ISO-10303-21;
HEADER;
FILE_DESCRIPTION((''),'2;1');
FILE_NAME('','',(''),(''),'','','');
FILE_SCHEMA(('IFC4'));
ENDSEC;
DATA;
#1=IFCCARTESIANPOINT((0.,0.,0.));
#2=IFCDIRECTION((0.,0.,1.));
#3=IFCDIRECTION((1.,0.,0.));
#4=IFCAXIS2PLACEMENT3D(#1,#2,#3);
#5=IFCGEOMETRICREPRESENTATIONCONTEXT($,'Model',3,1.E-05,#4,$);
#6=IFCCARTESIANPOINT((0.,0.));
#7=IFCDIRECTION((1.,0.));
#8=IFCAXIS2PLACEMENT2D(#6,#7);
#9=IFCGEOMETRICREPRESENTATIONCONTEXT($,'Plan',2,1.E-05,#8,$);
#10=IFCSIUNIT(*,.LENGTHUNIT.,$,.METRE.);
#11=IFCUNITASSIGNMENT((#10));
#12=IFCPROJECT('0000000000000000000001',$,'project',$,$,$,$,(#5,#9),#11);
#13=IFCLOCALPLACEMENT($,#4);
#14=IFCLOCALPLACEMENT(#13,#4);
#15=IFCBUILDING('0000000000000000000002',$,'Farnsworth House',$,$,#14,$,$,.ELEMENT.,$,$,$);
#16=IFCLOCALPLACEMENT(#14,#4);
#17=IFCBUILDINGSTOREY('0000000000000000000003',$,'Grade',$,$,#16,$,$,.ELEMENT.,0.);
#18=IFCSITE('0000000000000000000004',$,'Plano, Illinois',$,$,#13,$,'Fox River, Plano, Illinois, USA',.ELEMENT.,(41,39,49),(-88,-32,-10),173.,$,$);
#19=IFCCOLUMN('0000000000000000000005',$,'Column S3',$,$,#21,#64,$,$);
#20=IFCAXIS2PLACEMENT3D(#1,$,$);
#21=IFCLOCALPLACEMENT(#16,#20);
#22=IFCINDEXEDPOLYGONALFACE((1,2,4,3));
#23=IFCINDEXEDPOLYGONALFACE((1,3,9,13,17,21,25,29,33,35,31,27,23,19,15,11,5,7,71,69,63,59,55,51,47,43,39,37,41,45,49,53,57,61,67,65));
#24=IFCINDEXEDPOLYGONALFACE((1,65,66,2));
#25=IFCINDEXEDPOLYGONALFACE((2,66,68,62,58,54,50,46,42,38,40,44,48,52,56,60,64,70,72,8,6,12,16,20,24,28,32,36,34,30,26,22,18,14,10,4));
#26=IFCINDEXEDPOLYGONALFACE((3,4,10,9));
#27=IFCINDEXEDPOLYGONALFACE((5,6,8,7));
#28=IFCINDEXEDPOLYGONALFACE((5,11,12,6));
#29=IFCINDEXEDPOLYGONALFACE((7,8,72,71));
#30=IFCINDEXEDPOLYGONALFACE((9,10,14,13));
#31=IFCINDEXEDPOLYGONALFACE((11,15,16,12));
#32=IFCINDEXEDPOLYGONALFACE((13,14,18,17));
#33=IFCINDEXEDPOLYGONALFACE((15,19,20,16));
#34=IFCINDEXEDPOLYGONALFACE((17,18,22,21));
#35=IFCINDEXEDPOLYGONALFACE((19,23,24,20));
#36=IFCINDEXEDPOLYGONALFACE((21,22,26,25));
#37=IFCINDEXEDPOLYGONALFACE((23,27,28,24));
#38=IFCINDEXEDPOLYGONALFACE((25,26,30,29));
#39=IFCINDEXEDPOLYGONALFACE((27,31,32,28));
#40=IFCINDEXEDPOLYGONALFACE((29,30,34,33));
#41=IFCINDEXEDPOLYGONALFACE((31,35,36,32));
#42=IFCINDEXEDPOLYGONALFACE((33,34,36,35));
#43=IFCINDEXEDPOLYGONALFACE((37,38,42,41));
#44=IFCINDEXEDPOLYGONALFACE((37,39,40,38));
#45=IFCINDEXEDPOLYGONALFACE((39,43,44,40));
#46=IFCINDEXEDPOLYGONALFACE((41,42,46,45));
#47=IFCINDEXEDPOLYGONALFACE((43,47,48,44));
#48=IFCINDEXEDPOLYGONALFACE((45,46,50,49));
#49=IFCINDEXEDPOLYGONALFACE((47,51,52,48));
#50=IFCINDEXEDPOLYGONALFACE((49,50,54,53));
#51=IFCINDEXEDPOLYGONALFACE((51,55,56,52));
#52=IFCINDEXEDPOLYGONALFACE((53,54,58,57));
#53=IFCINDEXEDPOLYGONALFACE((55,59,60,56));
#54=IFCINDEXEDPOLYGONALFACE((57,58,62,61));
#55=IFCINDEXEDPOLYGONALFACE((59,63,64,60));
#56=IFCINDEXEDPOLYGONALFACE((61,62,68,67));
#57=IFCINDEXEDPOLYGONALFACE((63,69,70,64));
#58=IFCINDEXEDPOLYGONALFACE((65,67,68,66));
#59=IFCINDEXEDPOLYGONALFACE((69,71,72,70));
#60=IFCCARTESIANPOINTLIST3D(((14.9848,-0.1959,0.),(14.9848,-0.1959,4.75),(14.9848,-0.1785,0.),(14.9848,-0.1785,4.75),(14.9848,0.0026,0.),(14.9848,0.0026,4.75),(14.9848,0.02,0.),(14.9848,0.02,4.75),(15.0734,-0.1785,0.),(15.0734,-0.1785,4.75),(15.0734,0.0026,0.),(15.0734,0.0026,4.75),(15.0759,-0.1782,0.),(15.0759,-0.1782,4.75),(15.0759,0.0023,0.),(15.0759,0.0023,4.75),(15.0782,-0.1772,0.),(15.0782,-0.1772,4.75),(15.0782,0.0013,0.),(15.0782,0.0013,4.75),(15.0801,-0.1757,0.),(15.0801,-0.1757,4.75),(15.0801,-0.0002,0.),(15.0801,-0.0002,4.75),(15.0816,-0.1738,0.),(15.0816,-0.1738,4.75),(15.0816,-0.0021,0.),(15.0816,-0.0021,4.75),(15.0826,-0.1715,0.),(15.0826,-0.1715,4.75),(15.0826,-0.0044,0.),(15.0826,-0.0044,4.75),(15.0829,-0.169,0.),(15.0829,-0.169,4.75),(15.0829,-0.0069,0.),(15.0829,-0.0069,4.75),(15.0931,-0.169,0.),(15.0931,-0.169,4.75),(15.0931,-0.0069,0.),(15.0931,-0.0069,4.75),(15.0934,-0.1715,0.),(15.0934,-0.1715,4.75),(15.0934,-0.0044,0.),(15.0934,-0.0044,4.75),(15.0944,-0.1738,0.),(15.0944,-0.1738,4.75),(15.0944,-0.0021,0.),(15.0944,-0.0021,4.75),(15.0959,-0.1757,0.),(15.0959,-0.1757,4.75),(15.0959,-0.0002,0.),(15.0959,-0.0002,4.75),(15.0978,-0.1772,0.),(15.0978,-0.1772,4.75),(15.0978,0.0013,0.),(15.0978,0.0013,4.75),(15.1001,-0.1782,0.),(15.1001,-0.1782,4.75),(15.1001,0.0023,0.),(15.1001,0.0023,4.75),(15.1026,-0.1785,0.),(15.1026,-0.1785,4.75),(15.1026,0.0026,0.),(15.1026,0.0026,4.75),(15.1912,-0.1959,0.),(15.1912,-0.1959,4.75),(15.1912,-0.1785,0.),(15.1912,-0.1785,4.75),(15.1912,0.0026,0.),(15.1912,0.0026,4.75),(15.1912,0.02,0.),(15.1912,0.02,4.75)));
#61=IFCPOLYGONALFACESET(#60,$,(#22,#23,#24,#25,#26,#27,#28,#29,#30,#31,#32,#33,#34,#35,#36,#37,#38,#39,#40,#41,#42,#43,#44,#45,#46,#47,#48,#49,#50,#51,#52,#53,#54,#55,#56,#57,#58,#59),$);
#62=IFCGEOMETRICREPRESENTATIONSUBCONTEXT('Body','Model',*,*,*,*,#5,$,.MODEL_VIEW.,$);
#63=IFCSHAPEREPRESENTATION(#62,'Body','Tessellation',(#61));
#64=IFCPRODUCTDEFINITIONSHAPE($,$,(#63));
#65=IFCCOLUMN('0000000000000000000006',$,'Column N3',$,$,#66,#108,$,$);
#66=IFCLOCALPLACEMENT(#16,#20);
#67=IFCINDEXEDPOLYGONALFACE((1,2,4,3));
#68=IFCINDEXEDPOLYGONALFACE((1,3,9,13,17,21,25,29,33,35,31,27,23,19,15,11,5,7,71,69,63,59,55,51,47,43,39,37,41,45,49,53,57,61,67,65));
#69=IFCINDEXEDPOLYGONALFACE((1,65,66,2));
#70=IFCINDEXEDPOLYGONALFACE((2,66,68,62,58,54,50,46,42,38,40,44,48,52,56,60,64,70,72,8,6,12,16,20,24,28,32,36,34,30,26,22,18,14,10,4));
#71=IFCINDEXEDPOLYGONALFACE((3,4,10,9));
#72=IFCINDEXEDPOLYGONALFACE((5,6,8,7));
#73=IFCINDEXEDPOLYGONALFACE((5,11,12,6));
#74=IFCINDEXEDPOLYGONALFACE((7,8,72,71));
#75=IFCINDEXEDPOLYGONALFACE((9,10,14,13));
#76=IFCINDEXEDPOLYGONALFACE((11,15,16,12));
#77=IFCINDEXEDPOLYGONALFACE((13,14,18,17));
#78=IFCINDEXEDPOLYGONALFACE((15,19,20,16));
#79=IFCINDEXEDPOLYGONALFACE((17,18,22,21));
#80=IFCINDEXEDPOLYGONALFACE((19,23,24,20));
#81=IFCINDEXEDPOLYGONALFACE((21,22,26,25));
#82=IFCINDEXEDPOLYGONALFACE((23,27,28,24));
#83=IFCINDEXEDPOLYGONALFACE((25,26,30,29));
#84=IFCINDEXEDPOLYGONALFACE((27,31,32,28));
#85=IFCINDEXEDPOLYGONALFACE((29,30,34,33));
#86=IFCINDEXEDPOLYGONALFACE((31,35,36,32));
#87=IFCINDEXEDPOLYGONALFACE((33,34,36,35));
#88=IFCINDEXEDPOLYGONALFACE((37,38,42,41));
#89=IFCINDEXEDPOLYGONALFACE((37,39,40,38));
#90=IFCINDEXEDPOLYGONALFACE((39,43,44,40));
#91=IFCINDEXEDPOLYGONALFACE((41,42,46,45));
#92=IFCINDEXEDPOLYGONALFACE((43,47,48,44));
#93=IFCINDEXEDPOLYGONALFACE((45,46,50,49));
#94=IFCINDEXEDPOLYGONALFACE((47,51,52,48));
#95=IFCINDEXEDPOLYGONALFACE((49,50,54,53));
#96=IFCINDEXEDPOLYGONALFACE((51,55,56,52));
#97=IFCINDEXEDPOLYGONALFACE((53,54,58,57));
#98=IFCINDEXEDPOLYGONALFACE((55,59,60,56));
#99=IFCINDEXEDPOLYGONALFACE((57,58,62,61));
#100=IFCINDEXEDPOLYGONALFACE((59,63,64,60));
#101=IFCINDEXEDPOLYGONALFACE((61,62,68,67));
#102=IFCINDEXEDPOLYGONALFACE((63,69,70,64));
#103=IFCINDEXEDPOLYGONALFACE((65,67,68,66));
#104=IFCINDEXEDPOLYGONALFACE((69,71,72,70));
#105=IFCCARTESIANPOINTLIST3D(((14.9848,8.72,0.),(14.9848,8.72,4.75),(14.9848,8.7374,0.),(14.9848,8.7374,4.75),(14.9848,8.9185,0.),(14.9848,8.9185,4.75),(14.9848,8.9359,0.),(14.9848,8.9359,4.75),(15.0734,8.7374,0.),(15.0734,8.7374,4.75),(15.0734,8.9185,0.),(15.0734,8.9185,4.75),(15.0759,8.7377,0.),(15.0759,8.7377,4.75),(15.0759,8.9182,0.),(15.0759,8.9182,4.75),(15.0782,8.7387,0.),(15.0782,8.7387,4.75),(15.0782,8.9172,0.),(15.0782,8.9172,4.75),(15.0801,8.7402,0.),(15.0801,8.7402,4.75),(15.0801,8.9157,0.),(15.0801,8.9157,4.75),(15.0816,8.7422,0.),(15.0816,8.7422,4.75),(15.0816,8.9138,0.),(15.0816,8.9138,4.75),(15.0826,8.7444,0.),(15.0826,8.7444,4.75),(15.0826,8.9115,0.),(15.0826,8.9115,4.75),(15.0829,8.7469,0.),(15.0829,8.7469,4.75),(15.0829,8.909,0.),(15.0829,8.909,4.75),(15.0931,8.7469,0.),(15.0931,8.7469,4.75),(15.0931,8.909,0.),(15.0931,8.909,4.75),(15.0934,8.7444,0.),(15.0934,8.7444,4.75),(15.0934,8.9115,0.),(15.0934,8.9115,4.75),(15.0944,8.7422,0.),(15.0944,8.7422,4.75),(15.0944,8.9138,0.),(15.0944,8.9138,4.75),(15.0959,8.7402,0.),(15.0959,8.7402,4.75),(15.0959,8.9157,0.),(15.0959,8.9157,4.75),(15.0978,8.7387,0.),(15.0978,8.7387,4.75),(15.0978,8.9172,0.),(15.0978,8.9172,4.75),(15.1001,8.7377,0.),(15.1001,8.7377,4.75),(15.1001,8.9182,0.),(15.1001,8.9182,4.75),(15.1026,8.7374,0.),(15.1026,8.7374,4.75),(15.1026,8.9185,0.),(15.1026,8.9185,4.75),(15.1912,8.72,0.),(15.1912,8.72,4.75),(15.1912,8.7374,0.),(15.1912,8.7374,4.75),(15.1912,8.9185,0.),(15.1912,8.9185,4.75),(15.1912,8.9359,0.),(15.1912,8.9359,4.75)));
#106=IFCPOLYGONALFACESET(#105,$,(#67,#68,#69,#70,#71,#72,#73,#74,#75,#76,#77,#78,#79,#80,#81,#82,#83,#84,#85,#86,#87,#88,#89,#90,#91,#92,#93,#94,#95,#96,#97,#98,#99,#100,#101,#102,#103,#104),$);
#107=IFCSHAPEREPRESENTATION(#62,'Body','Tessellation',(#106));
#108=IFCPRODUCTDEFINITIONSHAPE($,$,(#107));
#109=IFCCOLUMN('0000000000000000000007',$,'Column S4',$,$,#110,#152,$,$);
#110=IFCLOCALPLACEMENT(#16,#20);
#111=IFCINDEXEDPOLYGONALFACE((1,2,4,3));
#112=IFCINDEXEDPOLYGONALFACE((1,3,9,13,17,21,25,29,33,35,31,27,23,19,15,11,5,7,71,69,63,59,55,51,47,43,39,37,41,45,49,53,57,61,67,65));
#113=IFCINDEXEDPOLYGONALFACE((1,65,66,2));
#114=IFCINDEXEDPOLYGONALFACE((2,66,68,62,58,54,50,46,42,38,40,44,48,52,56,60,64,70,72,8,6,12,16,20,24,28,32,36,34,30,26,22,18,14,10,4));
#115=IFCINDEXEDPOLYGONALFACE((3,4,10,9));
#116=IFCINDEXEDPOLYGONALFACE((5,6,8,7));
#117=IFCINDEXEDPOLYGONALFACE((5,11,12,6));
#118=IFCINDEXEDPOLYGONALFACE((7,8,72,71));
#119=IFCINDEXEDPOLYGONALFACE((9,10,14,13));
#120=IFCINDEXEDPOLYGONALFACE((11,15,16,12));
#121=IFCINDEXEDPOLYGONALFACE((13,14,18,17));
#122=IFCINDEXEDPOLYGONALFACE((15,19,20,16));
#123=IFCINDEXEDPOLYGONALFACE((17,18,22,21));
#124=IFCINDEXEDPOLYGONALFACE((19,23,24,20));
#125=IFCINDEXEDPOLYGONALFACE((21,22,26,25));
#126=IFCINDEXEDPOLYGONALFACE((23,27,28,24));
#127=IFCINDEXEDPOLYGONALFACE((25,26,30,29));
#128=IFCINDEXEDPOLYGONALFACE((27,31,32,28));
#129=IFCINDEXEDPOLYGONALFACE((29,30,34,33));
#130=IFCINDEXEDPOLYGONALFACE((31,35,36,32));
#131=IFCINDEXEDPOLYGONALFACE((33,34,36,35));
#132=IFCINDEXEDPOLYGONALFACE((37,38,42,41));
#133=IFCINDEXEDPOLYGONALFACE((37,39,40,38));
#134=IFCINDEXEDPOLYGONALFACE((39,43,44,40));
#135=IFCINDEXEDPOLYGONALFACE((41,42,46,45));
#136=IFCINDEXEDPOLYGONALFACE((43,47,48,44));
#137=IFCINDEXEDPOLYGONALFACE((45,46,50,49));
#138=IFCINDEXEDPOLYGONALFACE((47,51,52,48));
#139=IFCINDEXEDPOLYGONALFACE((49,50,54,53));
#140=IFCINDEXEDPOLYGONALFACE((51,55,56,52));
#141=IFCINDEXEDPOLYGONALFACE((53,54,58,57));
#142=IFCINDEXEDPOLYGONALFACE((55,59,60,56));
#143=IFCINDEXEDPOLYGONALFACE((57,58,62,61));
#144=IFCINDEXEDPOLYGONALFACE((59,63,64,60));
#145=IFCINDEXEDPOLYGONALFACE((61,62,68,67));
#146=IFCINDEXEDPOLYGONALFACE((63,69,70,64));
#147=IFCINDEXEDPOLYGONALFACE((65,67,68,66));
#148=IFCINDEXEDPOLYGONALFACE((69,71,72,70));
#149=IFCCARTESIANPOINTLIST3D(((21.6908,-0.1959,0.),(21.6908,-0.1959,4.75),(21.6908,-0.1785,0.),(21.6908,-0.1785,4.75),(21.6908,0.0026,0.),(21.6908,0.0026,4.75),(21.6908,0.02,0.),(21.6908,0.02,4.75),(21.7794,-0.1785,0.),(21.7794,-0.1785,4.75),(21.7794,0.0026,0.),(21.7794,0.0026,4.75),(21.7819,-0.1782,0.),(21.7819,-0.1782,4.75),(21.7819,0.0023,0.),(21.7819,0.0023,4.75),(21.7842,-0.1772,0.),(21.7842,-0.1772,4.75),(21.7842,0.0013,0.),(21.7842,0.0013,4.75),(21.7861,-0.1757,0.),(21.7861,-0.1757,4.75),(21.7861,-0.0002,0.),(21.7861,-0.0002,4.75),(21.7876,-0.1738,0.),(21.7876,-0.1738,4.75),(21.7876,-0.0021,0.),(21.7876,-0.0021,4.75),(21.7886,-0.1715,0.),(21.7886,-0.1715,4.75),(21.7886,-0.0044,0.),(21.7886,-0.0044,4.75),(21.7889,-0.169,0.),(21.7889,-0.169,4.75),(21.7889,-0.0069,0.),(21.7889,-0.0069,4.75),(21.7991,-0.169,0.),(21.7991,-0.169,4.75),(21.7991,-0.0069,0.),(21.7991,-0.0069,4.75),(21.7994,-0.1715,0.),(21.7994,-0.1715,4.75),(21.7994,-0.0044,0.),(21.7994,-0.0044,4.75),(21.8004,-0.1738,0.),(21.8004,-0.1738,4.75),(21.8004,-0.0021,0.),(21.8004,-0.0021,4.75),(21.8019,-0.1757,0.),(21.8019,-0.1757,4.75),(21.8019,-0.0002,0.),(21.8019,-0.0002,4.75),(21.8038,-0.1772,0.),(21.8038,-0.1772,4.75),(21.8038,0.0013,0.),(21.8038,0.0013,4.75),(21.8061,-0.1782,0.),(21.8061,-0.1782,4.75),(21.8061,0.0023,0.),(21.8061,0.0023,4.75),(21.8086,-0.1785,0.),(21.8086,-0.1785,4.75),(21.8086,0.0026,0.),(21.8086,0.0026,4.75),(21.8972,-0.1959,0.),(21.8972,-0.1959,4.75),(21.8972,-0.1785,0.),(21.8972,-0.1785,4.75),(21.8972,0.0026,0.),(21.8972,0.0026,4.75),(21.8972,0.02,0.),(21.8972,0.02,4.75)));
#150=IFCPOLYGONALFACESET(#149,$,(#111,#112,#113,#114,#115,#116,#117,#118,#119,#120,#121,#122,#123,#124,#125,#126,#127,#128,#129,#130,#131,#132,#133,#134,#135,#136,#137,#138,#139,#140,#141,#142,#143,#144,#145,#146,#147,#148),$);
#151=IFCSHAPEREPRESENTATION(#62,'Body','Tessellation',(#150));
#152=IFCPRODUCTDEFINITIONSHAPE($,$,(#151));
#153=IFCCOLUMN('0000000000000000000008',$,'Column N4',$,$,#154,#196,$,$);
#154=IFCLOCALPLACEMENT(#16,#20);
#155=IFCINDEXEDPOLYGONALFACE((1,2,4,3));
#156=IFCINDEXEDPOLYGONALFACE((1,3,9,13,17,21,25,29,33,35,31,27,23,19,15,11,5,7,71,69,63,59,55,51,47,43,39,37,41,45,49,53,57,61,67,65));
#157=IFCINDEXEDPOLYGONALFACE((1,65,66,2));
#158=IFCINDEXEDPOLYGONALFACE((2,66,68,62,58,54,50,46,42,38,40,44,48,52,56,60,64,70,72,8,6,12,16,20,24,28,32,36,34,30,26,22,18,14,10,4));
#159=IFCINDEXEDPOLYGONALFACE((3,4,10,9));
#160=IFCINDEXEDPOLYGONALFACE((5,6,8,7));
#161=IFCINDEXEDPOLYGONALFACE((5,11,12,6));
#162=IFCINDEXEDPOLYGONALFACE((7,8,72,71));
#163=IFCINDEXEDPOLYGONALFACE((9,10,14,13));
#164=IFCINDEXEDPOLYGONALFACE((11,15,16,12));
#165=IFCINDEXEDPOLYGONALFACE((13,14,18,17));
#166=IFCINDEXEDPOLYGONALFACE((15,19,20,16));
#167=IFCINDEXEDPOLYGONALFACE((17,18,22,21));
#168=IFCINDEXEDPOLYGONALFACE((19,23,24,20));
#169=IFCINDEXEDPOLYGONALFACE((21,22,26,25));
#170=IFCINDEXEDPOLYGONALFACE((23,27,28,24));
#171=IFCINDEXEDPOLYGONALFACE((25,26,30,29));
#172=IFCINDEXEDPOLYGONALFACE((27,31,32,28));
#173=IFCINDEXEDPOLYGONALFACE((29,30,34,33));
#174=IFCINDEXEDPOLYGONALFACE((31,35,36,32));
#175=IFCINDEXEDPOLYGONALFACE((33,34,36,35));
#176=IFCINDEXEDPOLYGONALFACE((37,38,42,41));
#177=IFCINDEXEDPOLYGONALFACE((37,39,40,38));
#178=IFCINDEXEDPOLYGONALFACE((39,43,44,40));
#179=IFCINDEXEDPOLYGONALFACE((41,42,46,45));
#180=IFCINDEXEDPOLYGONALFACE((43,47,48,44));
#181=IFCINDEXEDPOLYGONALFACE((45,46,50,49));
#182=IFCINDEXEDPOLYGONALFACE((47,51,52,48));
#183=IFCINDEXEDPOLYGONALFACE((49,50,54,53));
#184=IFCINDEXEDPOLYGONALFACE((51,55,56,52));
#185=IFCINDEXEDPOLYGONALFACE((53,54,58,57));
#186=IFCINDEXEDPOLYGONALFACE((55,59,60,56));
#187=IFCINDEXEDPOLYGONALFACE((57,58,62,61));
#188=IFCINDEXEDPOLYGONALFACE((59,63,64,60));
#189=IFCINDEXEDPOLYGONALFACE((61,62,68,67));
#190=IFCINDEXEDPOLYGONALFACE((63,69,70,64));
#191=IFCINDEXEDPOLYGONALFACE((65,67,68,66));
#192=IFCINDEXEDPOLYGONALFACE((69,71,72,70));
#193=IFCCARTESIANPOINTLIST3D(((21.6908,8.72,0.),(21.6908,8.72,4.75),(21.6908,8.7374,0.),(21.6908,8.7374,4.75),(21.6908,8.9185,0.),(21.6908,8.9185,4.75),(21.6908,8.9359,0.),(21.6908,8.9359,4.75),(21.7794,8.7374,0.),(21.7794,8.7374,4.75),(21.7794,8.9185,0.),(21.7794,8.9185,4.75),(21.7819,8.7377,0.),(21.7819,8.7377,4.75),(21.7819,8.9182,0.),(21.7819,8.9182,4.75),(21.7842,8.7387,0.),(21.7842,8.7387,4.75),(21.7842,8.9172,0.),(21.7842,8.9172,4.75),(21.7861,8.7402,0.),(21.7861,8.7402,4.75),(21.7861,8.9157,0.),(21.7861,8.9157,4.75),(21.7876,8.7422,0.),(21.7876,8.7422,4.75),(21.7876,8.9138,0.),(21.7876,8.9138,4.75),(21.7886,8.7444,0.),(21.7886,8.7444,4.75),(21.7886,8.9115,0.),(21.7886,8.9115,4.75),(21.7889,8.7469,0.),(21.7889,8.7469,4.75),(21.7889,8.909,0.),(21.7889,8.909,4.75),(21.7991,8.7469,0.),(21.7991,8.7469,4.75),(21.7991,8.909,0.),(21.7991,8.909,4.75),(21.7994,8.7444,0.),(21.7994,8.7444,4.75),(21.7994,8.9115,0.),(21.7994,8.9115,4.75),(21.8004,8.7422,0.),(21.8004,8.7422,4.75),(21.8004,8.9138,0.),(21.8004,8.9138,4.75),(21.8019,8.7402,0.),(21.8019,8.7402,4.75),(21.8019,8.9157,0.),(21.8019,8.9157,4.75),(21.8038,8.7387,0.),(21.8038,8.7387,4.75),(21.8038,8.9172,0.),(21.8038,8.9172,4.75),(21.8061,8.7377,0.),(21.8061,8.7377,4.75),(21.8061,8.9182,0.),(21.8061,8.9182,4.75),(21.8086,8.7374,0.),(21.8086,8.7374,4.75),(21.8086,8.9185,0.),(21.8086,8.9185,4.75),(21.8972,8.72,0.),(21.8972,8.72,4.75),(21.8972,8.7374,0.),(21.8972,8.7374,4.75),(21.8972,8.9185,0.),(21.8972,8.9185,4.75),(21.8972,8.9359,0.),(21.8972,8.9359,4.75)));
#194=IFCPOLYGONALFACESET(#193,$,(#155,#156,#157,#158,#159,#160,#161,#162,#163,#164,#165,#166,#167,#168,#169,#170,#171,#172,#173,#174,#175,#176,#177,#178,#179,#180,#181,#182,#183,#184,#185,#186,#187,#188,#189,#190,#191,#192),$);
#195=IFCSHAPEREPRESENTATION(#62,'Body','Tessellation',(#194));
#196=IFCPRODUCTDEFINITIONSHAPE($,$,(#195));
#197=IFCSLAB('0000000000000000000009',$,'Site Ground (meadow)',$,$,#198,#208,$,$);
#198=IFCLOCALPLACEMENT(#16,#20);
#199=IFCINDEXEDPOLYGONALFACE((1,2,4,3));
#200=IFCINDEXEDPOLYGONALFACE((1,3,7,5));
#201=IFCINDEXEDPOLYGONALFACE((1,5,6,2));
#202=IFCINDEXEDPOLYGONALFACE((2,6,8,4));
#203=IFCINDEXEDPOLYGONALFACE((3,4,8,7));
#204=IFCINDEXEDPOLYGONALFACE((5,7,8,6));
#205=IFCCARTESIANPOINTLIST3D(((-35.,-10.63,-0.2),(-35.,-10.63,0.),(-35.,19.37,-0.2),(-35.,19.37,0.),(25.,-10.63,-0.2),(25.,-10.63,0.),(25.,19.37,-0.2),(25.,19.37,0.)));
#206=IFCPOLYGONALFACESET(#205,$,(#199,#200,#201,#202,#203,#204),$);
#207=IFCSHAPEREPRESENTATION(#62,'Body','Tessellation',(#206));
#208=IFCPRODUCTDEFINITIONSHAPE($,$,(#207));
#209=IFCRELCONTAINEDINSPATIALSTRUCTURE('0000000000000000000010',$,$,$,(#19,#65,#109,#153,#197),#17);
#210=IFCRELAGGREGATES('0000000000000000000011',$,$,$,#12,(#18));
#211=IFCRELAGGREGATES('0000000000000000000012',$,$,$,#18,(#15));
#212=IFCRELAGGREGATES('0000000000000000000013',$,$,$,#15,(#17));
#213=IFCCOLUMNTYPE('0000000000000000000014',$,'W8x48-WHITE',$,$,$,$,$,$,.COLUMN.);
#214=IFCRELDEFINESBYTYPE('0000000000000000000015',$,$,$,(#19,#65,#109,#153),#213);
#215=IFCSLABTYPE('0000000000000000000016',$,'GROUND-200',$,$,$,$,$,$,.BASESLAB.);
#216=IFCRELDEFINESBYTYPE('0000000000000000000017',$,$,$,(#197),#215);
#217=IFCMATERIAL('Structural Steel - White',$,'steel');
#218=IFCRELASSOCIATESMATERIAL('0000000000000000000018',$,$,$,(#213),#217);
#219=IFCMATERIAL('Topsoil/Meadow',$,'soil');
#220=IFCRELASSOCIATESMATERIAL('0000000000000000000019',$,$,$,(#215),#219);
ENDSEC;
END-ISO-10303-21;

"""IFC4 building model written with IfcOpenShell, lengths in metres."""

from ifc_helpers import new_model, si_unit, frame, origin_with_axes, origin_2d_with_axis, place, context, subcontext, project, spatial, rectangle, i_section, extrude, material, material_profile, profile_set, profile_usage, type_object, element, save


model = new_model("IFC4")

# Units and contexts
model_context = context("Model", 3, precision=1e-05, world=origin_with_axes())
plan_context = context("Plan", 2, precision=1e-05, world=origin_2d_with_axis())
body_context = subcontext(model_context, "Body", "Model", "MODEL_VIEW")
ifc_project = project(units=[si_unit("LENGTHUNIT", "METRE")], contexts=[model_context, plan_context])

# Site, building, storey
site_placement = place(None, origin_with_axes())
site = spatial("IfcSite", under=ifc_project, at=site_placement, Name="Plano, Illinois", LongName="Fox River, Plano, Illinois, USA", CompositionType="ELEMENT", RefLatitude=(41, 39, 49), RefLongitude=(-88, -32, -10), RefElevation=173.0)
building_placement = place(site_placement, origin_with_axes())
building = spatial("IfcBuilding", under=site, at=building_placement, Name="Farnsworth House", CompositionType="ELEMENT")
storey_placement = place(building_placement, origin_with_axes())
storey = spatial("IfcBuildingStorey", under=building, at=storey_placement, Name="Grade", CompositionType="ELEMENT", Elevation=0.0)

# Columns
ifc_material_1 = material(Name="Structural Steel - White", Category="steel")
ifc_material_profile = material_profile(ifc_material_1, i_section(OverallWidth=0.2064, OverallDepth=0.2159, WebThickness=0.0102, FlangeThickness=0.0174, FilletRadius=0.0095, at=origin_2d_with_axis()), Name="W8x48-STEEL", Category="STRUCTURAL", Priority=0)
ifc_profile_set = profile_set([ifc_material_profile], Name="W8x48-STEEL")
ifc_profile_usage = profile_usage(ifc_profile_set)
column_type = type_object("IfcColumnType", Name="W8x48-WHITE", PredefinedType="COLUMN", material=ifc_profile_usage)
for number, where, z_axis, x_axis, name in (
    (1, (15.088, -0.088, 0.0), (0.0, 0.0, 1.0), (1.0, 0.0, 0.0), "Column S3"),
    (2, (15.088, 8.828, 0.0), (0.0, 0.0, 1.0), (1.0, 0.0, 0.0), "Column N3"),
    (3, (21.794, -0.088, 0.0), (0.0, 0.0, 1.0), (1.0, 0.0, 0.0), "Column S4"),
    (4, (21.794, 8.828, 0.0), (0.0, 0.0, 1.0), (1.0, 0.0, 0.0), "Column N4"),
):
    element("IfcColumn", number, at=place(storey_placement, frame(where, z_axis=z_axis, x_axis=x_axis)), inside=storey, type_object=column_type, Name=name, context=body_context, shape_type="SweptSolid", body=[
        extrude(i_section(OverallWidth=0.2064, OverallDepth=0.2159, WebThickness=0.0102, FlangeThickness=0.0174, FilletRadius=0.0095, at=origin_2d_with_axis()), origin_with_axes(), (0.0, 0.0, 1.0), 4.75),
    ])

# Slab
ifc_material_2 = material(Name="Topsoil/Meadow", Category="soil")
slab_type = type_object("IfcSlabType", Name="GROUND-200", PredefinedType="BASESLAB", material=ifc_material_2)
slab_placement = place(storey_placement, frame((-35.0, -10.63, -0.2), z_axis=(0.0, 0.0, 1.0), x_axis=(1.0, 0.0, 0.0)))
element("IfcSlab", 5, at=slab_placement, inside=storey, type_object=slab_type, Name="Site Ground (meadow)", context=body_context, shape_type="SweptSolid", body=[
    extrude(rectangle(XDim=60.0, YDim=30.0, at=origin_2d_with_axis()), frame((30.0, 15.0, 0.0), z_axis=(0.0, 0.0, 1.0), x_axis=(1.0, 0.0, 0.0)), (0.0, 0.0, 1.0), 0.2),
])

save(model, "model.ifc")
